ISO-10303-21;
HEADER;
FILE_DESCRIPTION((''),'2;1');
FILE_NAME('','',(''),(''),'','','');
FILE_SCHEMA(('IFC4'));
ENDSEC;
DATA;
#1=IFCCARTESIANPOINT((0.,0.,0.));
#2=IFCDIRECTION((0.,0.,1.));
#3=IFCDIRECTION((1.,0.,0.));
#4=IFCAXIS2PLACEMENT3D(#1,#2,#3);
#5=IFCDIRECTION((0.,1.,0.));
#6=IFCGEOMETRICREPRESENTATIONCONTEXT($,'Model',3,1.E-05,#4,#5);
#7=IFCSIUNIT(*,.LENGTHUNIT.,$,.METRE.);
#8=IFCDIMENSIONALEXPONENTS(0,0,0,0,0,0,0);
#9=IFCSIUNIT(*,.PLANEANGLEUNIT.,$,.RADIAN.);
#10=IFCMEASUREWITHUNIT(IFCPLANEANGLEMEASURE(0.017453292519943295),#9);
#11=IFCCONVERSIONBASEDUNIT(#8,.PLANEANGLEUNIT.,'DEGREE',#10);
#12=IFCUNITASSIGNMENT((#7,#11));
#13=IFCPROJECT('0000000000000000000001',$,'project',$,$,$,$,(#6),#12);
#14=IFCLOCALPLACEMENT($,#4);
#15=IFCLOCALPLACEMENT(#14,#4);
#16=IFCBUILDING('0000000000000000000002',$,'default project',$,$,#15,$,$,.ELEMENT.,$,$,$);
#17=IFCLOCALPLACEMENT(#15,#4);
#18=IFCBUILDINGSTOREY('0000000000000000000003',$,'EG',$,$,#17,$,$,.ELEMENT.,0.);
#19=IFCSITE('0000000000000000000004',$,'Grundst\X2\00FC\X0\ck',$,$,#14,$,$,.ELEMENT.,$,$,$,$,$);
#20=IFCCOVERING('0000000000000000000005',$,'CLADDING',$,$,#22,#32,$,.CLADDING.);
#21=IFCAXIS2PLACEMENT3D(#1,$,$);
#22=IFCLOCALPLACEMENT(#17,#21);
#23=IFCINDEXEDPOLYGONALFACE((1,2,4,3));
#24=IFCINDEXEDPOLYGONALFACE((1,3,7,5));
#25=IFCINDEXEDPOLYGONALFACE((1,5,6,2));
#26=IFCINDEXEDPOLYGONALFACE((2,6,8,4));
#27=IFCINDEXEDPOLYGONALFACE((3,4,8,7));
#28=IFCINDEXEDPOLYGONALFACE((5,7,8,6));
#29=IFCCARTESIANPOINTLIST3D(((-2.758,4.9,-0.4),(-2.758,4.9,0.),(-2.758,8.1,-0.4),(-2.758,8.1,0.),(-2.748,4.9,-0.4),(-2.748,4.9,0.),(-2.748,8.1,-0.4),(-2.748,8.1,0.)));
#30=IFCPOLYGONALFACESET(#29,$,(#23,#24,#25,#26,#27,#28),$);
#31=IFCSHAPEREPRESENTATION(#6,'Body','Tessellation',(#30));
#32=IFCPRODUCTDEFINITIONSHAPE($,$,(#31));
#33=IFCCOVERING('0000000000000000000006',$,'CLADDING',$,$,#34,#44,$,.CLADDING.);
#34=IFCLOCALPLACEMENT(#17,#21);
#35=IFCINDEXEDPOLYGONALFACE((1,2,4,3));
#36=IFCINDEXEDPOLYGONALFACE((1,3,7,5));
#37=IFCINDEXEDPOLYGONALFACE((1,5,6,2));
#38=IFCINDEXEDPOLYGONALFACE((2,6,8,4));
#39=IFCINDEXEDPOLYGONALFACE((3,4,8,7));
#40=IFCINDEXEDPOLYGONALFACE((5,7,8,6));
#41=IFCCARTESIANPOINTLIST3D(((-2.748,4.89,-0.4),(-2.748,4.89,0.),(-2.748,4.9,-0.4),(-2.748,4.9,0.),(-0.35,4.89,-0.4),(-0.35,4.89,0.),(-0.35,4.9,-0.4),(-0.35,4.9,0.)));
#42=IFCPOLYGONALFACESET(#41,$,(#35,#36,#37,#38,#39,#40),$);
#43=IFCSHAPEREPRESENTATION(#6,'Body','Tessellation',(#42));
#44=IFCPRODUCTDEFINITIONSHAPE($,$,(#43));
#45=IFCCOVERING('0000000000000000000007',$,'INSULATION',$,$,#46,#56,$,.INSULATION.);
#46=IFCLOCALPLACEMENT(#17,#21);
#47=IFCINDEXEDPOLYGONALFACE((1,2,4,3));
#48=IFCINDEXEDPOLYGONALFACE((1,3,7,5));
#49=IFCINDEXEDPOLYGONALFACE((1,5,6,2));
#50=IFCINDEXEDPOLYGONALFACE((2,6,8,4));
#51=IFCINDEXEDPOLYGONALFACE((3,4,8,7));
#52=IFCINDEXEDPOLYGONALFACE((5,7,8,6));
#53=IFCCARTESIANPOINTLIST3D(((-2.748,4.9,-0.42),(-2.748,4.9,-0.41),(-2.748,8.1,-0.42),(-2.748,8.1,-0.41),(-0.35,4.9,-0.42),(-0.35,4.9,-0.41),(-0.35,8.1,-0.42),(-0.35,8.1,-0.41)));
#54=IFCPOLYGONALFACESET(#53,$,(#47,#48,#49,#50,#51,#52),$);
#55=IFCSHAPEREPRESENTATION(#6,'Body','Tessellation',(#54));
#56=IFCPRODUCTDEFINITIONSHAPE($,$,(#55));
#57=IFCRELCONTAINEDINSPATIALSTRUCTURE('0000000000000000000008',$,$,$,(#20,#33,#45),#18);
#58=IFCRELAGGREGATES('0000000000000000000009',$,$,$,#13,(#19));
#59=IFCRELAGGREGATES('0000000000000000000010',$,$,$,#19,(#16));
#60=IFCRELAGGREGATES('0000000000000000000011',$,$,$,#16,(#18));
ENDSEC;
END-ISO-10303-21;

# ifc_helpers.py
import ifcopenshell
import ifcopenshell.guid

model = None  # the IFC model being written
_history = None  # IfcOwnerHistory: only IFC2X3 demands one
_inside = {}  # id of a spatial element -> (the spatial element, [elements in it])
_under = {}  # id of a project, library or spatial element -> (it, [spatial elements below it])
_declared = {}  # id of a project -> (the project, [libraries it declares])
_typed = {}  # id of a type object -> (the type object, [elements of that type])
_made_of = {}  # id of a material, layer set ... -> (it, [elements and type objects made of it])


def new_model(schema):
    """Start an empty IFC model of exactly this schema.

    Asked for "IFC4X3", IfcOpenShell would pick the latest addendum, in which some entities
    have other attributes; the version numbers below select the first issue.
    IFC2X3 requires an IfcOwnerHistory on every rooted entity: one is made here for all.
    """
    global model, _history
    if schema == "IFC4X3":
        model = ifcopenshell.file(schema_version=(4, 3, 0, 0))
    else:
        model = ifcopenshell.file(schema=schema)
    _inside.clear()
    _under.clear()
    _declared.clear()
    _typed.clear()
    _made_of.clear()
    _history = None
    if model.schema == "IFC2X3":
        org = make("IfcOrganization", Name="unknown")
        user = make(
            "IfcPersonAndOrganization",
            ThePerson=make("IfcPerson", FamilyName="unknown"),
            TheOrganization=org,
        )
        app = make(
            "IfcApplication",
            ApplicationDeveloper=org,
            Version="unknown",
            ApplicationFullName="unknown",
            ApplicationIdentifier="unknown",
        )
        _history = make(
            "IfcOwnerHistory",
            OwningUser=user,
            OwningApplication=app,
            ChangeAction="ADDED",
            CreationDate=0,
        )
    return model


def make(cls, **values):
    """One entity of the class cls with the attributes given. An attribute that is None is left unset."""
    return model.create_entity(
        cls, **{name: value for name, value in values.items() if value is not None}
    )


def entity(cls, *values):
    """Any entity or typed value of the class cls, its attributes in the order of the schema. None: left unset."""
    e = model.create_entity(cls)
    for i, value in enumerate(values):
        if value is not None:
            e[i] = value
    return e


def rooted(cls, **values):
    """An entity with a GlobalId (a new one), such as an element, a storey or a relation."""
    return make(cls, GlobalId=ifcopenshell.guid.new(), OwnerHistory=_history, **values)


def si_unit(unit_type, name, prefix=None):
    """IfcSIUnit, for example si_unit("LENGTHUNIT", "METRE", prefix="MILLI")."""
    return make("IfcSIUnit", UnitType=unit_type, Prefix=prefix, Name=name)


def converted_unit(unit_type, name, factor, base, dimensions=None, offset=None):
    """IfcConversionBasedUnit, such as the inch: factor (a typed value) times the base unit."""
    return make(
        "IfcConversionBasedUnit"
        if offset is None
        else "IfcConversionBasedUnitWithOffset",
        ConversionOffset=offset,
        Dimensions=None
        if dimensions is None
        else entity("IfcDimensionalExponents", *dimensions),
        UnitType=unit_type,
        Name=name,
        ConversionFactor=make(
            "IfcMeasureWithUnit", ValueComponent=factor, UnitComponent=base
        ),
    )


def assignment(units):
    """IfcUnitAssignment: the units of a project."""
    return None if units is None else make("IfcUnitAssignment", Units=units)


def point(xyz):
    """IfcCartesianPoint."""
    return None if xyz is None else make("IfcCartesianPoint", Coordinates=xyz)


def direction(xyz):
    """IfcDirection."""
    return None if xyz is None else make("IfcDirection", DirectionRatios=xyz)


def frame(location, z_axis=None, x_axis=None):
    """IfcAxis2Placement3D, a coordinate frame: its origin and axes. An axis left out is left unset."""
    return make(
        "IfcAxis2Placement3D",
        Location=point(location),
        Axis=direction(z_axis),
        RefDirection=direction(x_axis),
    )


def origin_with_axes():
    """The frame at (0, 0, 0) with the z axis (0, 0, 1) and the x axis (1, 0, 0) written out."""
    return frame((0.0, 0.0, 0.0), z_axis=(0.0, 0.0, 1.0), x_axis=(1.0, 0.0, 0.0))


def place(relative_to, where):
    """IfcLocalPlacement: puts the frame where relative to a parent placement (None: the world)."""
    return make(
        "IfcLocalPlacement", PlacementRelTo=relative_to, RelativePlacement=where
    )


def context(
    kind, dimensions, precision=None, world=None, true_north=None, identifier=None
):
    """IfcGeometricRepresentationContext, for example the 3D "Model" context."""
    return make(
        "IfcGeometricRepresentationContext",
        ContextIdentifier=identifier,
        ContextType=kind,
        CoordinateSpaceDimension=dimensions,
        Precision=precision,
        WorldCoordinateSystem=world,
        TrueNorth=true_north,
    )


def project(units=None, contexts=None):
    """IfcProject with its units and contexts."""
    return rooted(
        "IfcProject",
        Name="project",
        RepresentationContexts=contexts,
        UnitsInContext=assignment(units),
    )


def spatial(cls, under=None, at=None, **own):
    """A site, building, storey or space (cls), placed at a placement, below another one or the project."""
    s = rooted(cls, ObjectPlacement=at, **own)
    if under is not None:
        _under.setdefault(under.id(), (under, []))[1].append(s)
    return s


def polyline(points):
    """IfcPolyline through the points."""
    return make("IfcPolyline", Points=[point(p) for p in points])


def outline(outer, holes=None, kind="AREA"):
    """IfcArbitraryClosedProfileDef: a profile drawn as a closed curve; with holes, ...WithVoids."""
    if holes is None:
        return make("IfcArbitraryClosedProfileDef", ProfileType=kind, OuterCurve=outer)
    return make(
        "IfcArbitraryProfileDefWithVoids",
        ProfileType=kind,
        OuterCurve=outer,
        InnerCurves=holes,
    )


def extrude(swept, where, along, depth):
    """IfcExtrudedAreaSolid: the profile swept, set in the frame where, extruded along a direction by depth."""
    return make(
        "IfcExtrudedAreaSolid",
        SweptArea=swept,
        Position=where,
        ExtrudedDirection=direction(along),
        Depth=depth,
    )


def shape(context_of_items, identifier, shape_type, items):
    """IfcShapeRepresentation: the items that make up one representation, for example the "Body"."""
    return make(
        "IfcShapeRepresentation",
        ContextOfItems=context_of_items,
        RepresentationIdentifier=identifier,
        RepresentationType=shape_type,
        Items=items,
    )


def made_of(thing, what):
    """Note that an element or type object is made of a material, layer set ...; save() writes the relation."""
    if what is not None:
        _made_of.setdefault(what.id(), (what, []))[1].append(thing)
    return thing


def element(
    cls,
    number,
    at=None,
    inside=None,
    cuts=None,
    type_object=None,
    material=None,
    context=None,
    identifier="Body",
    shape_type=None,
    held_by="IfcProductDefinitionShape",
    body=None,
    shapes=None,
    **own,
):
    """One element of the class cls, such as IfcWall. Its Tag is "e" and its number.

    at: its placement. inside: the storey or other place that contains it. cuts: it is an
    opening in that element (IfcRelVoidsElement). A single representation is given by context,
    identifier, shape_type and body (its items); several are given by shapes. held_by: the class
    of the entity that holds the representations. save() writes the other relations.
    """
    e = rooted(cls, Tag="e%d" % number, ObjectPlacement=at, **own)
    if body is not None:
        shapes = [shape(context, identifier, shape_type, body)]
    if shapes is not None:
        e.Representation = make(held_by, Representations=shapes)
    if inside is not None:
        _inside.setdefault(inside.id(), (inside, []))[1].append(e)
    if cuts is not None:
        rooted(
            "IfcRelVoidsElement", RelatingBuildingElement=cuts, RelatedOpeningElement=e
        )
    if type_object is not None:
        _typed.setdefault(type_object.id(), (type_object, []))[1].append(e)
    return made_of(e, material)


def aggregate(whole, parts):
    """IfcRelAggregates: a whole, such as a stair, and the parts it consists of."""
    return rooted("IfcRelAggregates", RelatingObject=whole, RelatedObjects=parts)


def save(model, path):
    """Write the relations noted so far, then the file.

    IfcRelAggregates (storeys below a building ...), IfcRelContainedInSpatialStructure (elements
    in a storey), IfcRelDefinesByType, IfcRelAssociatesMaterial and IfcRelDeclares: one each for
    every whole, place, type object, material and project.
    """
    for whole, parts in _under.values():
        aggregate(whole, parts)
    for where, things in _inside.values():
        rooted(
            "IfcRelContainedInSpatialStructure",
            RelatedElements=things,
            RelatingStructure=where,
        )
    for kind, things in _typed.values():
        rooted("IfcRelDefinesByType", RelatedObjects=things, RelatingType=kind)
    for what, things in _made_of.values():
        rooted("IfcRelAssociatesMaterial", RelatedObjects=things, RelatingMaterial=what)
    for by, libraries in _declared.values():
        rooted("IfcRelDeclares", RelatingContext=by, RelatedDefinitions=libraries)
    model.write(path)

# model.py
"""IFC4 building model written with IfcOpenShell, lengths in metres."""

from ifc_helpers import new_model, entity, si_unit, converted_unit, direction, frame, origin_with_axes, place, context, project, spatial, polyline, outline, extrude, element, save


model = new_model("IFC4")

# Units and contexts
model_context = context("Model", 3, precision=1e-05, world=origin_with_axes(), true_north=direction((0.0, 1.0, 0.0)))
ifc_project = project(units=[si_unit("LENGTHUNIT", "METRE"), converted_unit("PLANEANGLEUNIT", "DEGREE", entity("IfcPlaneAngleMeasure", 0.017453292519943295), si_unit("PLANEANGLEUNIT", "RADIAN"), dimensions=[0, 0, 0, 0, 0, 0, 0])], contexts=[model_context])

# Site, building, storey
site_placement = place(None, origin_with_axes())
site = spatial("IfcSite", under=ifc_project, at=site_placement, Name="Grundstück", CompositionType="ELEMENT")
building_placement = place(site_placement, origin_with_axes())
building = spatial("IfcBuilding", under=site, at=building_placement, Name="default project", CompositionType="ELEMENT")
placement_1 = place(building_placement, origin_with_axes())
storey = spatial("IfcBuildingStorey", under=building, at=placement_1, Name="EG", CompositionType="ELEMENT", Elevation=0.0)

# Shared definitions
slab_1_placement = place(placement_1, frame((0.0, 0.0, -0.4), z_axis=(0.0, 0.0, 1.0), x_axis=(1.0, 0.0, 0.0)))
slab_2_placement = place(placement_1, frame((0.0, 0.0, -0.4), z_axis=(0.0, 0.0, 1.0), x_axis=(1.0, 0.0, 0.0)))

# Coverings
covering_1_placement = place(slab_2_placement, origin_with_axes())
element("IfcCovering", 1, at=covering_1_placement, inside=storey, Name="CLADDING", PredefinedType="CLADDING", context=model_context, shape_type="SweptSolid", body=[
    extrude(outline(polyline([(-2.758, 8.1), (-2.758, 4.9), (-2.748, 4.9), (-2.748, 8.1), (-2.758, 8.1)])), origin_with_axes(), (0.0, 0.0, 1.0), 0.4),
])
covering_2_placement = place(slab_2_placement, origin_with_axes())
element("IfcCovering", 2, at=covering_2_placement, inside=storey, Name="CLADDING", PredefinedType="CLADDING", context=model_context, shape_type="SweptSolid", body=[
    extrude(outline(polyline([(-2.748, 4.89), (-0.35, 4.89), (-0.35, 4.9), (-2.748, 4.9), (-2.748, 4.89)])), origin_with_axes(), (0.0, 0.0, 1.0), 0.4),
])
covering_3_placement = place(slab_1_placement, frame((0.0, 0.0, -0.01), z_axis=(0.0, 0.0, 1.0), x_axis=(1.0, 0.0, 0.0)))
element("IfcCovering", 3, at=covering_3_placement, inside=storey, Name="INSULATION", PredefinedType="INSULATION", context=model_context, shape_type="SweptSolid", body=[
    extrude(outline(polyline([(-0.35, 8.1), (-2.748, 8.1), (-2.748, 4.9), (-0.35, 4.9), (-0.35, 8.1)])), frame((0.0, 0.0, -0.01), z_axis=(0.0, 0.0, 1.0), x_axis=(1.0, 0.0, 0.0)), (0.0, 0.0, 1.0), 0.01),
])

save(model, "model.ifc")
